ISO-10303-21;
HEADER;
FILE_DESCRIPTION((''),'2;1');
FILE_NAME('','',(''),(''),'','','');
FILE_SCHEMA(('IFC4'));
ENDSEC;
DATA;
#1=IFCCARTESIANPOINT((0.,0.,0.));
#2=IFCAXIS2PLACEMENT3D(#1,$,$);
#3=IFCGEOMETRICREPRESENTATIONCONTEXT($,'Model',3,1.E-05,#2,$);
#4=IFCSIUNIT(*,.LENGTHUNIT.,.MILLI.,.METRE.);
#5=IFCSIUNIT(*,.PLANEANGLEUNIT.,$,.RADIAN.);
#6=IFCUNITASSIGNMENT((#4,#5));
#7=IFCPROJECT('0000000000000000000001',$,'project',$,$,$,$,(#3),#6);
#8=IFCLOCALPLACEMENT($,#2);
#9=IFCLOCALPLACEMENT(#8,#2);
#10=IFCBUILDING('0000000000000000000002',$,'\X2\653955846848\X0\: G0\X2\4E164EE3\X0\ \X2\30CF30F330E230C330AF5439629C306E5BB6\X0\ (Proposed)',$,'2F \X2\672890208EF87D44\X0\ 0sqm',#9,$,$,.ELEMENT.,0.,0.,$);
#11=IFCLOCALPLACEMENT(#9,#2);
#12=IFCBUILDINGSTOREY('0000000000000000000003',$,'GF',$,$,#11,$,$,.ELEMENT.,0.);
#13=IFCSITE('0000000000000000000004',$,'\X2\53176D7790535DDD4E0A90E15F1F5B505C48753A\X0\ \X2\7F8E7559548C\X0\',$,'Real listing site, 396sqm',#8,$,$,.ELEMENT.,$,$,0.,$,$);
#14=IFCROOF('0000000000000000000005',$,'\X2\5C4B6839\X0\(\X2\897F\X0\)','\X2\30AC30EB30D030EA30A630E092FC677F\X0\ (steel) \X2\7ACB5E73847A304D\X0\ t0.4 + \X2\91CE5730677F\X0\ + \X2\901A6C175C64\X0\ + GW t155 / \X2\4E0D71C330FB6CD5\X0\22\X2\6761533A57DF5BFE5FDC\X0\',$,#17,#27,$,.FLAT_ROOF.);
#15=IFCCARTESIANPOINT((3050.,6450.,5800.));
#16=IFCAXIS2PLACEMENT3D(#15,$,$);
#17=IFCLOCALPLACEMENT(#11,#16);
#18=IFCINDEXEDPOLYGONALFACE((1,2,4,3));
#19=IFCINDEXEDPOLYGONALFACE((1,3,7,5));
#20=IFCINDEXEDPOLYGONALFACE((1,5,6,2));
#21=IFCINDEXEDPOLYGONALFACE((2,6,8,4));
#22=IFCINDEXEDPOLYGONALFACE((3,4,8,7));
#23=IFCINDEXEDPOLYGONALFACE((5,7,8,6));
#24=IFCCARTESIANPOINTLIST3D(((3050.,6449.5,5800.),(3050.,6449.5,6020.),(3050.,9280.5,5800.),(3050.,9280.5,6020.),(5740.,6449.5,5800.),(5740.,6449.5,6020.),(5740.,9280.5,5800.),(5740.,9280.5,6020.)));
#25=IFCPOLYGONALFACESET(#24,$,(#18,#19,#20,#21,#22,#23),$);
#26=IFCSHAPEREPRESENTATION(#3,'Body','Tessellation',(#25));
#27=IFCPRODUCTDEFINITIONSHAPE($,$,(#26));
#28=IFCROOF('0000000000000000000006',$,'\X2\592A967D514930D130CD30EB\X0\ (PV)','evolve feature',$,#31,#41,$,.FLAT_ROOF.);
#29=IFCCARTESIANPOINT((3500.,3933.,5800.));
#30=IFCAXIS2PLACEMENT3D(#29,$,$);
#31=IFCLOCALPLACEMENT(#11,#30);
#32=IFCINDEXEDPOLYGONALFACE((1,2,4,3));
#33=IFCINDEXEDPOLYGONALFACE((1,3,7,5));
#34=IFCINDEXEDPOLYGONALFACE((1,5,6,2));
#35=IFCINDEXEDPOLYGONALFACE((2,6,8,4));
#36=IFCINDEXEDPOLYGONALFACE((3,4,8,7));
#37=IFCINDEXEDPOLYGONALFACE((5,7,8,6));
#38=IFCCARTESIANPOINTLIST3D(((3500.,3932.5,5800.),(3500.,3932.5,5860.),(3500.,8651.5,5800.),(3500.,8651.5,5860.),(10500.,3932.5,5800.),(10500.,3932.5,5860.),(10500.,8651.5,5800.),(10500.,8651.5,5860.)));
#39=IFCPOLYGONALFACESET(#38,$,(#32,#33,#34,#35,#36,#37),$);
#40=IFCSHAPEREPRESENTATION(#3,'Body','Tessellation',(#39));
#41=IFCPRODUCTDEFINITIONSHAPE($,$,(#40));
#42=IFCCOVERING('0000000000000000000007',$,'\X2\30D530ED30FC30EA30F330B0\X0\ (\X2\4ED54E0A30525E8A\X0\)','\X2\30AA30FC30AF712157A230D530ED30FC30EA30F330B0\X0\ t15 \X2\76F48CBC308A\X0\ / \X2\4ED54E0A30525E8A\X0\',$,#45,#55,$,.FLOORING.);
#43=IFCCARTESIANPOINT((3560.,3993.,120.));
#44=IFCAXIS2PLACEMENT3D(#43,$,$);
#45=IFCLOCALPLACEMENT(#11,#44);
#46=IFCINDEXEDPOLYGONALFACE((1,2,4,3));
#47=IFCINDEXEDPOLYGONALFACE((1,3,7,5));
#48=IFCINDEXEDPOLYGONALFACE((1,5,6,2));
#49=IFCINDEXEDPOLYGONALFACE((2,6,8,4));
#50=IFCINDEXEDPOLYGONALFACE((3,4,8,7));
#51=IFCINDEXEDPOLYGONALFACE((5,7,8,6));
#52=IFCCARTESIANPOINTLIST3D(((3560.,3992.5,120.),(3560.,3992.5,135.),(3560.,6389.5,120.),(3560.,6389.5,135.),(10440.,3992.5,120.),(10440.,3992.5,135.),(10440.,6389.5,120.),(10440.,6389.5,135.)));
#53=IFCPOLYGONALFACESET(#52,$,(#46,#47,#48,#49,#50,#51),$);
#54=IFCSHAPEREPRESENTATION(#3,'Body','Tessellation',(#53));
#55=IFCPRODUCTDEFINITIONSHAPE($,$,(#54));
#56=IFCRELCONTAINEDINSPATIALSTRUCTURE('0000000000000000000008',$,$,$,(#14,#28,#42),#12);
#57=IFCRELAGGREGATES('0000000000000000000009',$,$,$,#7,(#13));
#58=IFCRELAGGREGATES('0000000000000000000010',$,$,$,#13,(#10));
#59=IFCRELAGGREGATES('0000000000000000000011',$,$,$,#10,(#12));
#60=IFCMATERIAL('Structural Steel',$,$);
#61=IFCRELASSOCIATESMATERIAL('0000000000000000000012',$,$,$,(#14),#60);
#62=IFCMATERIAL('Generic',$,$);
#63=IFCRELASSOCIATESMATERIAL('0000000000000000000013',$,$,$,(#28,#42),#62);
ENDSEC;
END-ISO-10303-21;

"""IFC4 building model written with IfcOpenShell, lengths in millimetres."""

from ifc_helpers import new_model, si_unit, frame, frame_2d, origin, place, context, project, spatial, rectangle, extrude, material, element, save


model = new_model("IFC4")

# Units and contexts
model_context = context("Model", 3, precision=1e-05, world=origin())
ifc_project = project(units=[si_unit("LENGTHUNIT", "METRE", prefix="MILLI"), si_unit("PLANEANGLEUNIT", "RADIAN")], contexts=[model_context])

# Site, building, storey
site_placement = place(None, origin())
site = spatial("IfcSite", under=ifc_project, at=site_placement, Name="北海道川上郡弟子屈町 美留和", ObjectType="Real listing site, 396sqm", CompositionType="ELEMENT", RefElevation=0.0)
building_placement = place(site_placement, origin())
building = spatial("IfcBuilding", under=site, at=building_placement, Name="改善案: G0世代 ハンモック吹抜の家 (Proposed)", ObjectType="2F 木造軸組 0sqm", CompositionType="ELEMENT", ElevationOfRefHeight=0.0, ElevationOfTerrain=0.0)
storey_placement = place(building_placement, origin())
storey = spatial("IfcBuildingStorey", under=building, at=storey_placement, Name="GF", CompositionType="ELEMENT", Elevation=0.0)

# Shared definitions
ifc_material_1 = material(Name="Generic")

# Roofs
ifc_material_2 = material(Name="Structural Steel")
roof_1_placement = place(storey_placement, frame((3050.0, 6450.0, 5800.0)))
element("IfcRoof", 1, at=roof_1_placement, inside=storey, material=ifc_material_2, Name="屋根(西)", Description="ガルバリウム鋼板 (steel) 立平葺き t0.4 + 野地板 + 通気層 + GW t155 / 不燃・法22条区域対応", PredefinedType="FLAT_ROOF", context=model_context, shape_type="SweptSolid", body=[
    extrude(rectangle(XDim=2690.0, YDim=2831.0, at=frame_2d((1345.0, 1415.0))), frame((3050.0, 6450.0, 5800.0)), (0.0, 0.0, 1.0), 220.0),
])
roof_2_placement = place(storey_placement, frame((3500.0, 3933.0, 5800.0)))
element("IfcRoof", 2, at=roof_2_placement, inside=storey, material=ifc_material_1, Name="太陽光パネル (PV)", Description="evolve feature", PredefinedType="FLAT_ROOF", context=model_context, shape_type="SweptSolid", body=[
    extrude(rectangle(XDim=7000.0, YDim=4719.0, at=frame_2d((3500.0, 2359.0))), frame((3500.0, 3933.0, 5800.0)), (0.0, 0.0, 1.0), 60.0),
])

# Covering
covering_placement = place(storey_placement, frame((3560.0, 3993.0, 120.0)))
element("IfcCovering", 3, at=covering_placement, inside=storey, material=ifc_material_1, Name="フローリング (仕上げ床)", Description="オーク無垢フローリング t15 直貼り / 仕上げ床", PredefinedType="FLOORING", context=model_context, shape_type="SweptSolid", body=[
    extrude(rectangle(XDim=6880.0, YDim=2397.0, at=frame_2d((3440.0, 1198.0))), frame((3560.0, 3993.0, 120.0)), (0.0, 0.0, 1.0), 15.0),
])

save(model, "model.ifc")
